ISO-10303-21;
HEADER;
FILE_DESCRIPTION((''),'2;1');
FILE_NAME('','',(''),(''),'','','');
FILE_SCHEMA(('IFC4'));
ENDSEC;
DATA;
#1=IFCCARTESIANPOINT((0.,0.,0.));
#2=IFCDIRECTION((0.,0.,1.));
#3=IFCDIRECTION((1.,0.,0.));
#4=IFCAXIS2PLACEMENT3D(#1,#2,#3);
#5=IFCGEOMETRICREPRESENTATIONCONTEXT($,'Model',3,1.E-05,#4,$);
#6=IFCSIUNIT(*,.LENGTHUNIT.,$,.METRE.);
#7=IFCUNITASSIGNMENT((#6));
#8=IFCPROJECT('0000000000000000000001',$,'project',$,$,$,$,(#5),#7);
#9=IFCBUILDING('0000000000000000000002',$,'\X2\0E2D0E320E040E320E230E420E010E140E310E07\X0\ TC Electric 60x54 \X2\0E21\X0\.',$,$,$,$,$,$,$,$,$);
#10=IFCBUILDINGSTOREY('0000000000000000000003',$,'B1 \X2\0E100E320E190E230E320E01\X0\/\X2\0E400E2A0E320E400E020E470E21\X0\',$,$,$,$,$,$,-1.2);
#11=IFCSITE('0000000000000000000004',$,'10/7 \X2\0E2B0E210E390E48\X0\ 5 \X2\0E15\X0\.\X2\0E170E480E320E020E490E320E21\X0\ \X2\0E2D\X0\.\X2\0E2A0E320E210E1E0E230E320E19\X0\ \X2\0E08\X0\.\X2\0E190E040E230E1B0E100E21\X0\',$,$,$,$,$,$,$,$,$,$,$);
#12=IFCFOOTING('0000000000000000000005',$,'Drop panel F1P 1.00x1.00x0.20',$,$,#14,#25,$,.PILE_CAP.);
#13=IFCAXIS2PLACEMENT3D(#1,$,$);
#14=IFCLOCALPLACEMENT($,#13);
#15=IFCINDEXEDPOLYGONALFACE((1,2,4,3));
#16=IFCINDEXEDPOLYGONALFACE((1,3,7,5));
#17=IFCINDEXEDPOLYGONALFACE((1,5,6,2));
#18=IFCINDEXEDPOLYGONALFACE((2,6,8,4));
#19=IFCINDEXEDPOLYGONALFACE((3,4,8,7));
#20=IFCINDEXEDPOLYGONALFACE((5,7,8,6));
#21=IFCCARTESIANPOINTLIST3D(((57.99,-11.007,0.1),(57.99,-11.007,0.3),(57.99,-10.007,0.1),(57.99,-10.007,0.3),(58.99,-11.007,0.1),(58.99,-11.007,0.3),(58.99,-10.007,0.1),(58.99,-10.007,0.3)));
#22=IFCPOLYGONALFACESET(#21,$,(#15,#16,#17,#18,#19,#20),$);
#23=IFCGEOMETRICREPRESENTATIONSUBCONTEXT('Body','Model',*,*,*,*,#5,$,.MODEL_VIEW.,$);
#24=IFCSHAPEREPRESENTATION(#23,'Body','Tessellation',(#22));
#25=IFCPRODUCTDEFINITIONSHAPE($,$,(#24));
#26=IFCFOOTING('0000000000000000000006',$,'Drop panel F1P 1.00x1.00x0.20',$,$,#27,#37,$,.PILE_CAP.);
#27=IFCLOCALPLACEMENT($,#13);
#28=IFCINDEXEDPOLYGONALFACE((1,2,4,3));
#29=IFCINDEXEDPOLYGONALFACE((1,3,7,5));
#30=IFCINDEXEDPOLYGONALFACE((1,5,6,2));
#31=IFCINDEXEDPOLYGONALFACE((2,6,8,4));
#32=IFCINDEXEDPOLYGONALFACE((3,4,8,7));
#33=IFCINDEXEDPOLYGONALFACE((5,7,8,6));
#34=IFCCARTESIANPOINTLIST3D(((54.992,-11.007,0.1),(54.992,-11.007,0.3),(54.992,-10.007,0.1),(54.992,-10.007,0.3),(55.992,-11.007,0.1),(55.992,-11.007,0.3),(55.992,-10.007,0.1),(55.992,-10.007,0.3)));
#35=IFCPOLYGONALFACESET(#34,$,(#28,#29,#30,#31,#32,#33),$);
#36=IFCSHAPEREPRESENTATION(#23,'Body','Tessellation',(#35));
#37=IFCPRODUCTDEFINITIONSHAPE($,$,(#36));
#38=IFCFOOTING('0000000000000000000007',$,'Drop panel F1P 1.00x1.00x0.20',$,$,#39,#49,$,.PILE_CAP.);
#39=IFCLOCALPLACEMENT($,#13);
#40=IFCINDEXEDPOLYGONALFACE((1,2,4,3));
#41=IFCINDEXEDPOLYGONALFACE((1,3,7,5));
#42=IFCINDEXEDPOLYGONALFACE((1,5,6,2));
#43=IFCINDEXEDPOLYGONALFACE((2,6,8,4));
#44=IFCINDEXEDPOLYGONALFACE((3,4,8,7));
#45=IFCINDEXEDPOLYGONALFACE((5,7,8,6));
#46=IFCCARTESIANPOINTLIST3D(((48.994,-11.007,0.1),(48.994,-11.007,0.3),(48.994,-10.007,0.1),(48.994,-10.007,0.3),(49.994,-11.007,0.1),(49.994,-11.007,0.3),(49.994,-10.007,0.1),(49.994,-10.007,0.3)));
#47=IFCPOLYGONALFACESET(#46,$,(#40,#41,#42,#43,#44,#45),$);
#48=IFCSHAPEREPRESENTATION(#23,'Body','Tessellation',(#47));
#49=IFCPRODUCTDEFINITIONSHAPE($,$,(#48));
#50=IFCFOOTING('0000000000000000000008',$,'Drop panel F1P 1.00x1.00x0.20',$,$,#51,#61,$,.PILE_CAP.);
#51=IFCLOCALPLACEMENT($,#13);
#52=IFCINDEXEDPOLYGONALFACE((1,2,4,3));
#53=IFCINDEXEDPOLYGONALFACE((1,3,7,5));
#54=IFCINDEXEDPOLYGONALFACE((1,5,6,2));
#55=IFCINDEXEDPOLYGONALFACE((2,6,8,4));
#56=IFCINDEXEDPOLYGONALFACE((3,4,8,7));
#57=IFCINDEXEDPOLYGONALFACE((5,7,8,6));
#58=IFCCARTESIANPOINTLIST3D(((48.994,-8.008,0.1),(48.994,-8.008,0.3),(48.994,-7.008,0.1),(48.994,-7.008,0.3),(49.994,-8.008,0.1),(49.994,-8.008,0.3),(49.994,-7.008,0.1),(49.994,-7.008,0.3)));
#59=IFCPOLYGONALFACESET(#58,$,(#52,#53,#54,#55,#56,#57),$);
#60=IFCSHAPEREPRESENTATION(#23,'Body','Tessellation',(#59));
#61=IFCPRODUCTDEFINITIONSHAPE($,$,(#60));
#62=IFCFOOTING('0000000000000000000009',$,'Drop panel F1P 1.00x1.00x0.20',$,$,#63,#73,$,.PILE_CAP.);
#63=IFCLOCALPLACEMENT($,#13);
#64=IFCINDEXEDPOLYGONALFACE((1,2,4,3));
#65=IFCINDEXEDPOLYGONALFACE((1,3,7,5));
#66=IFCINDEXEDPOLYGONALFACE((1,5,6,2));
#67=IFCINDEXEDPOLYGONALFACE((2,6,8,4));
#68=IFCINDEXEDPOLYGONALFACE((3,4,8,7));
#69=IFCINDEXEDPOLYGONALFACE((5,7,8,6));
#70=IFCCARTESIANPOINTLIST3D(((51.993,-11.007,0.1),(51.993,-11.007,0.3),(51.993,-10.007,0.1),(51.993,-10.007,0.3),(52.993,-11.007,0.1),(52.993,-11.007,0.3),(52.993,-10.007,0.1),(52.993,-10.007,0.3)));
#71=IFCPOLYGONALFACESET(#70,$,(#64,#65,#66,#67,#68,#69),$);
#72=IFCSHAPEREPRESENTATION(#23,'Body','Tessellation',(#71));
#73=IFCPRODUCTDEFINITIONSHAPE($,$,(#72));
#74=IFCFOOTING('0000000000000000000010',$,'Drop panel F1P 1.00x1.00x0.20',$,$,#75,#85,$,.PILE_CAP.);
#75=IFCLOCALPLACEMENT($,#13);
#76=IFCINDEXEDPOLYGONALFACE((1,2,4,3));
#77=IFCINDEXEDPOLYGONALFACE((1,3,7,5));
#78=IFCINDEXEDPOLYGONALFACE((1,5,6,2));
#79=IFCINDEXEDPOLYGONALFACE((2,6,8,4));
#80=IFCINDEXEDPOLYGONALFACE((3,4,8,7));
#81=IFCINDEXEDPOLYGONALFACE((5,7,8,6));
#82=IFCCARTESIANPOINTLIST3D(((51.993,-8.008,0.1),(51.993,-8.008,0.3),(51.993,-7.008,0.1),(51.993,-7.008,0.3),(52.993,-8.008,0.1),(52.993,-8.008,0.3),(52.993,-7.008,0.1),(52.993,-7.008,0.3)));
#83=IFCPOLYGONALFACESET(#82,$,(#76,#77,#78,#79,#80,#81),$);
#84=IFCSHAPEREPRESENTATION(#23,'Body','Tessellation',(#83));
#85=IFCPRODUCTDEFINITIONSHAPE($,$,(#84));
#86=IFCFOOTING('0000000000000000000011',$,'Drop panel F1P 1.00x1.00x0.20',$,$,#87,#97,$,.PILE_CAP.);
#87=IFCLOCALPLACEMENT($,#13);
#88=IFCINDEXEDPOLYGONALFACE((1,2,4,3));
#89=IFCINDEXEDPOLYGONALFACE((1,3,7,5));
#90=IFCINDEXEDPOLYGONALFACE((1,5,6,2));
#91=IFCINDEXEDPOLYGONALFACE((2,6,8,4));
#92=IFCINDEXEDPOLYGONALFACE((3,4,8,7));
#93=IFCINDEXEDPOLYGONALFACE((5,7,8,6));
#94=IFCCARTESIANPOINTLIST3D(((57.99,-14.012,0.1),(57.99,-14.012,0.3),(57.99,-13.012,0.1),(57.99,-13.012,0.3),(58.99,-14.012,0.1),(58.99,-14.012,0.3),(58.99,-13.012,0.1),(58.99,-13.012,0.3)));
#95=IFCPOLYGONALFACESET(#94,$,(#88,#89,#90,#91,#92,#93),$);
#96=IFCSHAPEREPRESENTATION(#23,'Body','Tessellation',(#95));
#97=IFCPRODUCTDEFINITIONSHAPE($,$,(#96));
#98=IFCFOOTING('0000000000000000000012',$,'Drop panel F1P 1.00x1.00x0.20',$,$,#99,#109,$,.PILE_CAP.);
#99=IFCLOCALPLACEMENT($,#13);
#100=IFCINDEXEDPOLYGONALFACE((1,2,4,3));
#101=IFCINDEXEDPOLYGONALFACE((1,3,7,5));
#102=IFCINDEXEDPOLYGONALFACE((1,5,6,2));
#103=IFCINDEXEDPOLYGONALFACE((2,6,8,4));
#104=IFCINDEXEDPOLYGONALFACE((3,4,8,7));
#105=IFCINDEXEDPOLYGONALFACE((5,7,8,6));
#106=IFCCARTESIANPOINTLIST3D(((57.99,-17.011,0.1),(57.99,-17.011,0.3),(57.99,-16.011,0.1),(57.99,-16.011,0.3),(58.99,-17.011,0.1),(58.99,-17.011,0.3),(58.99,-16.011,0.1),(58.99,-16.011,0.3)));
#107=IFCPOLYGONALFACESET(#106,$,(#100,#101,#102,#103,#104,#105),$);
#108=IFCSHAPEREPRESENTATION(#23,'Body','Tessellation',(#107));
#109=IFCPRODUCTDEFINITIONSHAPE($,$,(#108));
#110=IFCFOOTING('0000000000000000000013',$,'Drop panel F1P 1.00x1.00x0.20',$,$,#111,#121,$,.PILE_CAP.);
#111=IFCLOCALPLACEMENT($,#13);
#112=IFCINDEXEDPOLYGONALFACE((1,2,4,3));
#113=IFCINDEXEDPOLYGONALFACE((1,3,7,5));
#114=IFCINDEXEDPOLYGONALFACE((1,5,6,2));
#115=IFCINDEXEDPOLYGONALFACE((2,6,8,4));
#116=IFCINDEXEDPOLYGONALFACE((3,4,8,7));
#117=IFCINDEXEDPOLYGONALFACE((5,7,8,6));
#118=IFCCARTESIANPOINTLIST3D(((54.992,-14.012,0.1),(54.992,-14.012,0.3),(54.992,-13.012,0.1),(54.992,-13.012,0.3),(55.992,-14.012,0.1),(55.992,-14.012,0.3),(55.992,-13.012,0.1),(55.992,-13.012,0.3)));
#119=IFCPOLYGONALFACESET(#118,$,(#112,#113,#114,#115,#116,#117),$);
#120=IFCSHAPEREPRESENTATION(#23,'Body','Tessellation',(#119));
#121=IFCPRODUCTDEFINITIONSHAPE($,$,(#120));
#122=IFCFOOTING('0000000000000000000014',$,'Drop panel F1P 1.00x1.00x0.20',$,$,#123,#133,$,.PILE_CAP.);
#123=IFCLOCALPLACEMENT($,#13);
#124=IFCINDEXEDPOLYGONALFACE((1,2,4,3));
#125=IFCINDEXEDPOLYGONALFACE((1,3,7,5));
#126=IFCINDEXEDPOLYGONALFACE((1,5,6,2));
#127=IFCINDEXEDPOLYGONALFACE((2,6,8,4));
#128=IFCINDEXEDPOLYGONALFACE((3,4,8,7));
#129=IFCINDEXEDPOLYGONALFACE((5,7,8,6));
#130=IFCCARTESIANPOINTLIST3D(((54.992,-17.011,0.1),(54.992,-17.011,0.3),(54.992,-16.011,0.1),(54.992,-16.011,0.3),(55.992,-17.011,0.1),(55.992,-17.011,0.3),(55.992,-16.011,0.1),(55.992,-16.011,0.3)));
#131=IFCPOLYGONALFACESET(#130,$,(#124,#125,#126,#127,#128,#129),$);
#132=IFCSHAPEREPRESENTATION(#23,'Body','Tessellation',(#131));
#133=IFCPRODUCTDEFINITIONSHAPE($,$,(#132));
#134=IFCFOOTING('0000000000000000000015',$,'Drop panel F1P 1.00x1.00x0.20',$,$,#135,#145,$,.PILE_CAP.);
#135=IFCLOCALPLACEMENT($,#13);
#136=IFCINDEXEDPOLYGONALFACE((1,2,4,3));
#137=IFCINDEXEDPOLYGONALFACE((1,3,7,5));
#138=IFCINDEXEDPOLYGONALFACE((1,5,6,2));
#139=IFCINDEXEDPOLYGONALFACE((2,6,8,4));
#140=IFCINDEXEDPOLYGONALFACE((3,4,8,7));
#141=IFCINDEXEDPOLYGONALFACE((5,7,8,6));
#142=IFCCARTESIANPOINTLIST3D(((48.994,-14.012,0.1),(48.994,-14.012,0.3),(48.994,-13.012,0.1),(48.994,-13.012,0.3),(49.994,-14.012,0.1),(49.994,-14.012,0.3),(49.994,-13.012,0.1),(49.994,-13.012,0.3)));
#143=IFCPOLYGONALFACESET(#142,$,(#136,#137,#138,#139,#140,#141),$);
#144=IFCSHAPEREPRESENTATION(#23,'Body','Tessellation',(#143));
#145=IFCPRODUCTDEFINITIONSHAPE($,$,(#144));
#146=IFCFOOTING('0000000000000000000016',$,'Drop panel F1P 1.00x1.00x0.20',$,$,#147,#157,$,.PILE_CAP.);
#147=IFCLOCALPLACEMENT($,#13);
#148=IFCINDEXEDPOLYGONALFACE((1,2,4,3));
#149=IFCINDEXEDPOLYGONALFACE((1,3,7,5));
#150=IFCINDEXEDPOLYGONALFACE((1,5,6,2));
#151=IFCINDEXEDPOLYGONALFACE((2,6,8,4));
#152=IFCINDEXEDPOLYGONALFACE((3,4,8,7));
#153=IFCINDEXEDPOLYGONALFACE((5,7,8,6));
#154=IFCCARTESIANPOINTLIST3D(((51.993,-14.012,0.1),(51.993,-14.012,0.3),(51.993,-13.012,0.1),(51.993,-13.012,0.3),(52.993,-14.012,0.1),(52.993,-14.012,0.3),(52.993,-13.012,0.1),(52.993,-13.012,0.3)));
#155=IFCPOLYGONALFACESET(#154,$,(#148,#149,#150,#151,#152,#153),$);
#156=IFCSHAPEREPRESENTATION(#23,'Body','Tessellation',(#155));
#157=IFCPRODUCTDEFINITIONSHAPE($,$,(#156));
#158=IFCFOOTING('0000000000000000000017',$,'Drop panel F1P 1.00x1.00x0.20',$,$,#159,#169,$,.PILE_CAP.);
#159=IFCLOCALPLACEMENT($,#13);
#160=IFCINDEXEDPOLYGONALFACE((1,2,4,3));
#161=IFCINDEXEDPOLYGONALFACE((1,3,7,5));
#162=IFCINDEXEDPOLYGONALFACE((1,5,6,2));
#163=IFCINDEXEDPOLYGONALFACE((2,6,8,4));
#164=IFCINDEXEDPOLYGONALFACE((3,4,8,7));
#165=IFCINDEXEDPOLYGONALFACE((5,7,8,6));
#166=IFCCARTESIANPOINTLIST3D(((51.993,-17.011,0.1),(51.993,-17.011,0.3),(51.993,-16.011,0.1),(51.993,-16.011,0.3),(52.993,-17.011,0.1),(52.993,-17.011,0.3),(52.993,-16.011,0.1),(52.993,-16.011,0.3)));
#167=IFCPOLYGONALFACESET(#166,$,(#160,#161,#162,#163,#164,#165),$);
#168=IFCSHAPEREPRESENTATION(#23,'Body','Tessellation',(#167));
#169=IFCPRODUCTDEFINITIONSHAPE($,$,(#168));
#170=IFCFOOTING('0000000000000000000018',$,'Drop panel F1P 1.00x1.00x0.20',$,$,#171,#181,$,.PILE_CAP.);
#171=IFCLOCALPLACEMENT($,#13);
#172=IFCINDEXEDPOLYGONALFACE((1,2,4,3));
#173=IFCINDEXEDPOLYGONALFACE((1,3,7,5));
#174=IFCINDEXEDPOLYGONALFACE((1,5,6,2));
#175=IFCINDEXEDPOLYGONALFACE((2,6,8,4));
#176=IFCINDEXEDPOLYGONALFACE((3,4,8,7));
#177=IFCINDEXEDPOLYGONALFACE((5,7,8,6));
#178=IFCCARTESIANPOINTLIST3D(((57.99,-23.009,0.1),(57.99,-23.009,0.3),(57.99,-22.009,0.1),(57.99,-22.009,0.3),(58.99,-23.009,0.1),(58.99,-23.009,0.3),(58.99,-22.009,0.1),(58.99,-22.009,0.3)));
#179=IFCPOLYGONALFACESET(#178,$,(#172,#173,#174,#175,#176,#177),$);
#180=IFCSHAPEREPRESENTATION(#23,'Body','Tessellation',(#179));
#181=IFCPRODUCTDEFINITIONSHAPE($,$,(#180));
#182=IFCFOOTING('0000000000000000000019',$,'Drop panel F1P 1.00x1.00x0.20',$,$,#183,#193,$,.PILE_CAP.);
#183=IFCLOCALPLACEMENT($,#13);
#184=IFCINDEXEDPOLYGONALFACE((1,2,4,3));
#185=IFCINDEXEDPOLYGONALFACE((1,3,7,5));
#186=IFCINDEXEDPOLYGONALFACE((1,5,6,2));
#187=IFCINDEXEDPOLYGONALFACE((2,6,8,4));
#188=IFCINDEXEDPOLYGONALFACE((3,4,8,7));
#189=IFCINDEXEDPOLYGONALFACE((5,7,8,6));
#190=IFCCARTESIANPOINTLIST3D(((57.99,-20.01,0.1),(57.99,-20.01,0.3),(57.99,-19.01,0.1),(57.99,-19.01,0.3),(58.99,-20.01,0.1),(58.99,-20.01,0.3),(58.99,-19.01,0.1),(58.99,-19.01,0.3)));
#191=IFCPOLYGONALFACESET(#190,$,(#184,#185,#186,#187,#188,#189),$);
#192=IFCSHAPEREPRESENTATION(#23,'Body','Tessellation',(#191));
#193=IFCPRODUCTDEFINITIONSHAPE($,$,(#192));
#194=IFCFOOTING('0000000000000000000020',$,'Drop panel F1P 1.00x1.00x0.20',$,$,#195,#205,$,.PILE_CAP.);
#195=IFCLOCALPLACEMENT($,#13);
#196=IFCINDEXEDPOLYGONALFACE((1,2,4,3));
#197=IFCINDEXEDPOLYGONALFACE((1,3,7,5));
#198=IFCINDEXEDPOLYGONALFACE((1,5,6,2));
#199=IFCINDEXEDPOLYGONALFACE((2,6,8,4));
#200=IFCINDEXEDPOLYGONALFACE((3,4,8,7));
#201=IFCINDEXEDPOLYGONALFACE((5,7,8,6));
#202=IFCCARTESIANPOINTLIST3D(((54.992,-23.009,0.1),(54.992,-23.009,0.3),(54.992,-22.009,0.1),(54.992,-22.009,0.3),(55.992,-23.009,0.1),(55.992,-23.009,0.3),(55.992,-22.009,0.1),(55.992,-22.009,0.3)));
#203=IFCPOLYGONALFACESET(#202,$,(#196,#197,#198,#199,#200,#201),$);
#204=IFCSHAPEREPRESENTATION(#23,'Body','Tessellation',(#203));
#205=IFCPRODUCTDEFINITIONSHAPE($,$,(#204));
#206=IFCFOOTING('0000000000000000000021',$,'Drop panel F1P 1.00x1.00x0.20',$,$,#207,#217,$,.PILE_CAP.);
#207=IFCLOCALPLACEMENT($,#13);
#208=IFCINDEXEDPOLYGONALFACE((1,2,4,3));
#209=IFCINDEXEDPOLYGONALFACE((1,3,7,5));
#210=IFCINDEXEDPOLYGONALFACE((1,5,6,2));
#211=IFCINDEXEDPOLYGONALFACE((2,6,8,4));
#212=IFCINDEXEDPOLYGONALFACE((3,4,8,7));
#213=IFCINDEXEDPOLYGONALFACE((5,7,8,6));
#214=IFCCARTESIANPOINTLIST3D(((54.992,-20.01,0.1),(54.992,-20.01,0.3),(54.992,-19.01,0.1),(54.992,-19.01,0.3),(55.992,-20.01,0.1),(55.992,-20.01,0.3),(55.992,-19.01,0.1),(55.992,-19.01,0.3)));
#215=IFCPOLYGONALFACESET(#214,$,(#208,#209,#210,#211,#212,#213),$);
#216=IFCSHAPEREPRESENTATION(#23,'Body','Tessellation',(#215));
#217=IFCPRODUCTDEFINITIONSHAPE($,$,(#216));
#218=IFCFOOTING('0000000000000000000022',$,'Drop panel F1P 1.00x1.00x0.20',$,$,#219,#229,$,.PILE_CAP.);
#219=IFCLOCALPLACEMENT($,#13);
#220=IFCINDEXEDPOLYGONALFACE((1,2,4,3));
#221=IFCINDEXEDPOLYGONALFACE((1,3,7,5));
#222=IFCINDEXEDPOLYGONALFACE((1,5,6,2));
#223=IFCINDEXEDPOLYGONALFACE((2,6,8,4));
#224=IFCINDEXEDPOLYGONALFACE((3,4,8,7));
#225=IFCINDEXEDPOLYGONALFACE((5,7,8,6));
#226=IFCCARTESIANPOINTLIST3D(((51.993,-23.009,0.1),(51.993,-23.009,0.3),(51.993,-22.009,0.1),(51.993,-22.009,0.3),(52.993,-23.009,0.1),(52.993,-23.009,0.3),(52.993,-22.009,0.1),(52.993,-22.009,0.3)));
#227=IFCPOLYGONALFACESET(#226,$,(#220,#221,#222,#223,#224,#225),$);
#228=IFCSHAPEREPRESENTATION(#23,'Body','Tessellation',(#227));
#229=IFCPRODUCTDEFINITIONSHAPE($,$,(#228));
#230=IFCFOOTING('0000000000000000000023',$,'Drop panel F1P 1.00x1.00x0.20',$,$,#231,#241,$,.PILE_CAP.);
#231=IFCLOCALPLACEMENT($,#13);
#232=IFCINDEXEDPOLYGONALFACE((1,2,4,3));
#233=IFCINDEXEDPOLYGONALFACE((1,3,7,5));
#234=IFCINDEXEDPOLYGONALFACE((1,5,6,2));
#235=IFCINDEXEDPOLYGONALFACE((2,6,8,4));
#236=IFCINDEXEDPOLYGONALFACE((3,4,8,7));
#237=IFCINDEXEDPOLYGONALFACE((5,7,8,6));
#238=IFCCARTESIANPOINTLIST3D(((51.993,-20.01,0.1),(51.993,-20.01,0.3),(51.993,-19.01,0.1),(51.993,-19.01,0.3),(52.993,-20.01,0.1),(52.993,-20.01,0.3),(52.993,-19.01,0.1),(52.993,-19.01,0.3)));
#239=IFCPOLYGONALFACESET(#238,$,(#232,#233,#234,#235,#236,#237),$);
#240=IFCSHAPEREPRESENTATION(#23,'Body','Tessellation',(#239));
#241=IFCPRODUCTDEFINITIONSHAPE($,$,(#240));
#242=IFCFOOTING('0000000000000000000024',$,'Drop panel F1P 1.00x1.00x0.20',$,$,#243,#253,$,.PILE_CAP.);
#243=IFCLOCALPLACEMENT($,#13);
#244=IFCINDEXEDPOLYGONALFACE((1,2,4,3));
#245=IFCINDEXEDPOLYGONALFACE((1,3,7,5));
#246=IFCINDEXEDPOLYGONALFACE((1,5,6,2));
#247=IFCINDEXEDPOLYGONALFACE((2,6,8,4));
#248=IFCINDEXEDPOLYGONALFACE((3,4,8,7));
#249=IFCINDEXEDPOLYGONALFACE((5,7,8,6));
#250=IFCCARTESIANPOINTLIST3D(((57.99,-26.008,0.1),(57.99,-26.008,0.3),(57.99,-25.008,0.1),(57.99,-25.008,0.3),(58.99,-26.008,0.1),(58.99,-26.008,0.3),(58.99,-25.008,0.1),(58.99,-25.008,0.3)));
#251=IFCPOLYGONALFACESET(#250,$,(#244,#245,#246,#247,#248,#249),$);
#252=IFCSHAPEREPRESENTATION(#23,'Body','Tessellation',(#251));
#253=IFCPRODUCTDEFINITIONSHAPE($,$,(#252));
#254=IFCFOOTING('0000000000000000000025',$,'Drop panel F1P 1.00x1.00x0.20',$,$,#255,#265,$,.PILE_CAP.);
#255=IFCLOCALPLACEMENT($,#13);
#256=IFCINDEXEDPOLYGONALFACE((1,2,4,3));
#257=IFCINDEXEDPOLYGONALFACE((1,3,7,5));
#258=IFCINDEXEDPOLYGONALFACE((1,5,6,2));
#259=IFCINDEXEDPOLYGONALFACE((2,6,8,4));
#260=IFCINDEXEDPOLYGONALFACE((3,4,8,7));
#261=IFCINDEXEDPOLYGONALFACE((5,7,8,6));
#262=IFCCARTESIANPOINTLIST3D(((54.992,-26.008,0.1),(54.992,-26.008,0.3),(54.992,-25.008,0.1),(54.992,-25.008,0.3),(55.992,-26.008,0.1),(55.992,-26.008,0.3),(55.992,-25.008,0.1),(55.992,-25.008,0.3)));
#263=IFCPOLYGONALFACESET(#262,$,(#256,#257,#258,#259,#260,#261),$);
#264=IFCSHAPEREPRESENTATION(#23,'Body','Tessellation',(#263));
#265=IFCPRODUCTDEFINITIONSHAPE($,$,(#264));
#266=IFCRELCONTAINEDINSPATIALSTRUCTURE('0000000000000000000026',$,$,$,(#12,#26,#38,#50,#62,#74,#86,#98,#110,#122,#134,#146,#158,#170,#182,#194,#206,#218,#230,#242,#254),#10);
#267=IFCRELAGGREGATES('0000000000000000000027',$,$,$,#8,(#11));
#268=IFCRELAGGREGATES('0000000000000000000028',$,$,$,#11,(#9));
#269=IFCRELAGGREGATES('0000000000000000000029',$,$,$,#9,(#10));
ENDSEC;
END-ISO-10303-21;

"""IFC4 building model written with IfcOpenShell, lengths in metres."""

from ifc_helpers import new_model, si_unit, frame, origin, origin_with_axes, origin_2d, place, context, subcontext, project, spatial, rectangle, extrude, element, save


model = new_model("IFC4")

# Units and contexts
model_context = context("Model", 3, precision=1e-05, world=origin_with_axes())
body_context = subcontext(model_context, "Body", "Model", "MODEL_VIEW")
ifc_project = project(units=[si_unit("LENGTHUNIT", "METRE")], contexts=[model_context])

# Site, building, storey
site = spatial("IfcSite", under=ifc_project, Name="10/7 หมู่ 5 ต.ท่าข้าม อ.สามพราน จ.นครปฐม")
building = spatial("IfcBuilding", under=site, Name="อาคารโกดัง TC Electric 60x54 ม.")
storey = spatial("IfcBuildingStorey", under=building, Name="B1 ฐานราก/เสาเข็ม", Elevation=-1.2)

# Footings
for number, where, z_axis, x_axis, name in (
    (1, (58.49, -10.507, 0.1), (0.0, 0.0, 1.0), (1.0, 0.0, 0.0), "Drop panel F1P 1.00x1.00x0.20"),
    (2, (55.492, -10.507, 0.1), (0.0, 0.0, 1.0), (1.0, 0.0, 0.0), "Drop panel F1P 1.00x1.00x0.20"),
    (3, (49.494, -10.507, 0.1), (0.0, 0.0, 1.0), (1.0, 0.0, 0.0), "Drop panel F1P 1.00x1.00x0.20"),
    (4, (49.494, -7.508, 0.1), (0.0, 0.0, 1.0), (1.0, 0.0, 0.0), "Drop panel F1P 1.00x1.00x0.20"),
    (5, (52.493, -10.507, 0.1), (0.0, 0.0, 1.0), (1.0, 0.0, 0.0), "Drop panel F1P 1.00x1.00x0.20"),
    (6, (52.493, -7.508, 0.1), (0.0, 0.0, 1.0), (1.0, 0.0, 0.0), "Drop panel F1P 1.00x1.00x0.20"),
    (7, (58.49, -13.512, 0.1), (0.0, 0.0, 1.0), (1.0, 0.0, 0.0), "Drop panel F1P 1.00x1.00x0.20"),
    (8, (58.49, -16.511, 0.1), (0.0, 0.0, 1.0), (1.0, 0.0, 0.0), "Drop panel F1P 1.00x1.00x0.20"),
    (9, (55.492, -13.512, 0.1), (0.0, 0.0, 1.0), (1.0, 0.0, 0.0), "Drop panel F1P 1.00x1.00x0.20"),
    (10, (55.492, -16.511, 0.1), (0.0, 0.0, 1.0), (1.0, 0.0, 0.0), "Drop panel F1P 1.00x1.00x0.20"),
    (11, (49.494, -13.512, 0.1), (0.0, 0.0, 1.0), (1.0, 0.0, 0.0), "Drop panel F1P 1.00x1.00x0.20"),
    (12, (52.493, -13.512, 0.1), (0.0, 0.0, 1.0), (1.0, 0.0, 0.0), "Drop panel F1P 1.00x1.00x0.20"),
    (13, (52.493, -16.511, 0.1), (0.0, 0.0, 1.0), (1.0, 0.0, 0.0), "Drop panel F1P 1.00x1.00x0.20"),
    (14, (58.49, -22.509, 0.1), (0.0, 0.0, 1.0), (1.0, 0.0, 0.0), "Drop panel F1P 1.00x1.00x0.20"),
    (15, (58.49, -19.51, 0.1), (0.0, 0.0, 1.0), (1.0, 0.0, 0.0), "Drop panel F1P 1.00x1.00x0.20"),
    (16, (55.492, -22.509, 0.1), (0.0, 0.0, 1.0), (1.0, 0.0, 0.0), "Drop panel F1P 1.00x1.00x0.20"),
    (17, (55.492, -19.51, 0.1), (0.0, 0.0, 1.0), (1.0, 0.0, 0.0), "Drop panel F1P 1.00x1.00x0.20"),
    (18, (52.493, -22.509, 0.1), (0.0, 0.0, 1.0), (1.0, 0.0, 0.0), "Drop panel F1P 1.00x1.00x0.20"),
    (19, (52.493, -19.51, 0.1), (0.0, 0.0, 1.0), (1.0, 0.0, 0.0), "Drop panel F1P 1.00x1.00x0.20"),
    (20, (58.49, -25.508, 0.1), (0.0, 0.0, 1.0), (1.0, 0.0, 0.0), "Drop panel F1P 1.00x1.00x0.20"),
    (21, (55.492, -25.508, 0.1), (0.0, 0.0, 1.0), (1.0, 0.0, 0.0), "Drop panel F1P 1.00x1.00x0.20"),
):
    element("IfcFooting", number, at=place(None, frame(where, z_axis=z_axis, x_axis=x_axis)), inside=storey, Name=name, PredefinedType="PILE_CAP", context=body_context, shape_type="SweptSolid", body=[
        extrude(rectangle(XDim=1.0, YDim=1.0, at=origin_2d()), origin(), (0.0, 0.0, 1.0), 0.2),
    ])

save(model, "model.ifc")
